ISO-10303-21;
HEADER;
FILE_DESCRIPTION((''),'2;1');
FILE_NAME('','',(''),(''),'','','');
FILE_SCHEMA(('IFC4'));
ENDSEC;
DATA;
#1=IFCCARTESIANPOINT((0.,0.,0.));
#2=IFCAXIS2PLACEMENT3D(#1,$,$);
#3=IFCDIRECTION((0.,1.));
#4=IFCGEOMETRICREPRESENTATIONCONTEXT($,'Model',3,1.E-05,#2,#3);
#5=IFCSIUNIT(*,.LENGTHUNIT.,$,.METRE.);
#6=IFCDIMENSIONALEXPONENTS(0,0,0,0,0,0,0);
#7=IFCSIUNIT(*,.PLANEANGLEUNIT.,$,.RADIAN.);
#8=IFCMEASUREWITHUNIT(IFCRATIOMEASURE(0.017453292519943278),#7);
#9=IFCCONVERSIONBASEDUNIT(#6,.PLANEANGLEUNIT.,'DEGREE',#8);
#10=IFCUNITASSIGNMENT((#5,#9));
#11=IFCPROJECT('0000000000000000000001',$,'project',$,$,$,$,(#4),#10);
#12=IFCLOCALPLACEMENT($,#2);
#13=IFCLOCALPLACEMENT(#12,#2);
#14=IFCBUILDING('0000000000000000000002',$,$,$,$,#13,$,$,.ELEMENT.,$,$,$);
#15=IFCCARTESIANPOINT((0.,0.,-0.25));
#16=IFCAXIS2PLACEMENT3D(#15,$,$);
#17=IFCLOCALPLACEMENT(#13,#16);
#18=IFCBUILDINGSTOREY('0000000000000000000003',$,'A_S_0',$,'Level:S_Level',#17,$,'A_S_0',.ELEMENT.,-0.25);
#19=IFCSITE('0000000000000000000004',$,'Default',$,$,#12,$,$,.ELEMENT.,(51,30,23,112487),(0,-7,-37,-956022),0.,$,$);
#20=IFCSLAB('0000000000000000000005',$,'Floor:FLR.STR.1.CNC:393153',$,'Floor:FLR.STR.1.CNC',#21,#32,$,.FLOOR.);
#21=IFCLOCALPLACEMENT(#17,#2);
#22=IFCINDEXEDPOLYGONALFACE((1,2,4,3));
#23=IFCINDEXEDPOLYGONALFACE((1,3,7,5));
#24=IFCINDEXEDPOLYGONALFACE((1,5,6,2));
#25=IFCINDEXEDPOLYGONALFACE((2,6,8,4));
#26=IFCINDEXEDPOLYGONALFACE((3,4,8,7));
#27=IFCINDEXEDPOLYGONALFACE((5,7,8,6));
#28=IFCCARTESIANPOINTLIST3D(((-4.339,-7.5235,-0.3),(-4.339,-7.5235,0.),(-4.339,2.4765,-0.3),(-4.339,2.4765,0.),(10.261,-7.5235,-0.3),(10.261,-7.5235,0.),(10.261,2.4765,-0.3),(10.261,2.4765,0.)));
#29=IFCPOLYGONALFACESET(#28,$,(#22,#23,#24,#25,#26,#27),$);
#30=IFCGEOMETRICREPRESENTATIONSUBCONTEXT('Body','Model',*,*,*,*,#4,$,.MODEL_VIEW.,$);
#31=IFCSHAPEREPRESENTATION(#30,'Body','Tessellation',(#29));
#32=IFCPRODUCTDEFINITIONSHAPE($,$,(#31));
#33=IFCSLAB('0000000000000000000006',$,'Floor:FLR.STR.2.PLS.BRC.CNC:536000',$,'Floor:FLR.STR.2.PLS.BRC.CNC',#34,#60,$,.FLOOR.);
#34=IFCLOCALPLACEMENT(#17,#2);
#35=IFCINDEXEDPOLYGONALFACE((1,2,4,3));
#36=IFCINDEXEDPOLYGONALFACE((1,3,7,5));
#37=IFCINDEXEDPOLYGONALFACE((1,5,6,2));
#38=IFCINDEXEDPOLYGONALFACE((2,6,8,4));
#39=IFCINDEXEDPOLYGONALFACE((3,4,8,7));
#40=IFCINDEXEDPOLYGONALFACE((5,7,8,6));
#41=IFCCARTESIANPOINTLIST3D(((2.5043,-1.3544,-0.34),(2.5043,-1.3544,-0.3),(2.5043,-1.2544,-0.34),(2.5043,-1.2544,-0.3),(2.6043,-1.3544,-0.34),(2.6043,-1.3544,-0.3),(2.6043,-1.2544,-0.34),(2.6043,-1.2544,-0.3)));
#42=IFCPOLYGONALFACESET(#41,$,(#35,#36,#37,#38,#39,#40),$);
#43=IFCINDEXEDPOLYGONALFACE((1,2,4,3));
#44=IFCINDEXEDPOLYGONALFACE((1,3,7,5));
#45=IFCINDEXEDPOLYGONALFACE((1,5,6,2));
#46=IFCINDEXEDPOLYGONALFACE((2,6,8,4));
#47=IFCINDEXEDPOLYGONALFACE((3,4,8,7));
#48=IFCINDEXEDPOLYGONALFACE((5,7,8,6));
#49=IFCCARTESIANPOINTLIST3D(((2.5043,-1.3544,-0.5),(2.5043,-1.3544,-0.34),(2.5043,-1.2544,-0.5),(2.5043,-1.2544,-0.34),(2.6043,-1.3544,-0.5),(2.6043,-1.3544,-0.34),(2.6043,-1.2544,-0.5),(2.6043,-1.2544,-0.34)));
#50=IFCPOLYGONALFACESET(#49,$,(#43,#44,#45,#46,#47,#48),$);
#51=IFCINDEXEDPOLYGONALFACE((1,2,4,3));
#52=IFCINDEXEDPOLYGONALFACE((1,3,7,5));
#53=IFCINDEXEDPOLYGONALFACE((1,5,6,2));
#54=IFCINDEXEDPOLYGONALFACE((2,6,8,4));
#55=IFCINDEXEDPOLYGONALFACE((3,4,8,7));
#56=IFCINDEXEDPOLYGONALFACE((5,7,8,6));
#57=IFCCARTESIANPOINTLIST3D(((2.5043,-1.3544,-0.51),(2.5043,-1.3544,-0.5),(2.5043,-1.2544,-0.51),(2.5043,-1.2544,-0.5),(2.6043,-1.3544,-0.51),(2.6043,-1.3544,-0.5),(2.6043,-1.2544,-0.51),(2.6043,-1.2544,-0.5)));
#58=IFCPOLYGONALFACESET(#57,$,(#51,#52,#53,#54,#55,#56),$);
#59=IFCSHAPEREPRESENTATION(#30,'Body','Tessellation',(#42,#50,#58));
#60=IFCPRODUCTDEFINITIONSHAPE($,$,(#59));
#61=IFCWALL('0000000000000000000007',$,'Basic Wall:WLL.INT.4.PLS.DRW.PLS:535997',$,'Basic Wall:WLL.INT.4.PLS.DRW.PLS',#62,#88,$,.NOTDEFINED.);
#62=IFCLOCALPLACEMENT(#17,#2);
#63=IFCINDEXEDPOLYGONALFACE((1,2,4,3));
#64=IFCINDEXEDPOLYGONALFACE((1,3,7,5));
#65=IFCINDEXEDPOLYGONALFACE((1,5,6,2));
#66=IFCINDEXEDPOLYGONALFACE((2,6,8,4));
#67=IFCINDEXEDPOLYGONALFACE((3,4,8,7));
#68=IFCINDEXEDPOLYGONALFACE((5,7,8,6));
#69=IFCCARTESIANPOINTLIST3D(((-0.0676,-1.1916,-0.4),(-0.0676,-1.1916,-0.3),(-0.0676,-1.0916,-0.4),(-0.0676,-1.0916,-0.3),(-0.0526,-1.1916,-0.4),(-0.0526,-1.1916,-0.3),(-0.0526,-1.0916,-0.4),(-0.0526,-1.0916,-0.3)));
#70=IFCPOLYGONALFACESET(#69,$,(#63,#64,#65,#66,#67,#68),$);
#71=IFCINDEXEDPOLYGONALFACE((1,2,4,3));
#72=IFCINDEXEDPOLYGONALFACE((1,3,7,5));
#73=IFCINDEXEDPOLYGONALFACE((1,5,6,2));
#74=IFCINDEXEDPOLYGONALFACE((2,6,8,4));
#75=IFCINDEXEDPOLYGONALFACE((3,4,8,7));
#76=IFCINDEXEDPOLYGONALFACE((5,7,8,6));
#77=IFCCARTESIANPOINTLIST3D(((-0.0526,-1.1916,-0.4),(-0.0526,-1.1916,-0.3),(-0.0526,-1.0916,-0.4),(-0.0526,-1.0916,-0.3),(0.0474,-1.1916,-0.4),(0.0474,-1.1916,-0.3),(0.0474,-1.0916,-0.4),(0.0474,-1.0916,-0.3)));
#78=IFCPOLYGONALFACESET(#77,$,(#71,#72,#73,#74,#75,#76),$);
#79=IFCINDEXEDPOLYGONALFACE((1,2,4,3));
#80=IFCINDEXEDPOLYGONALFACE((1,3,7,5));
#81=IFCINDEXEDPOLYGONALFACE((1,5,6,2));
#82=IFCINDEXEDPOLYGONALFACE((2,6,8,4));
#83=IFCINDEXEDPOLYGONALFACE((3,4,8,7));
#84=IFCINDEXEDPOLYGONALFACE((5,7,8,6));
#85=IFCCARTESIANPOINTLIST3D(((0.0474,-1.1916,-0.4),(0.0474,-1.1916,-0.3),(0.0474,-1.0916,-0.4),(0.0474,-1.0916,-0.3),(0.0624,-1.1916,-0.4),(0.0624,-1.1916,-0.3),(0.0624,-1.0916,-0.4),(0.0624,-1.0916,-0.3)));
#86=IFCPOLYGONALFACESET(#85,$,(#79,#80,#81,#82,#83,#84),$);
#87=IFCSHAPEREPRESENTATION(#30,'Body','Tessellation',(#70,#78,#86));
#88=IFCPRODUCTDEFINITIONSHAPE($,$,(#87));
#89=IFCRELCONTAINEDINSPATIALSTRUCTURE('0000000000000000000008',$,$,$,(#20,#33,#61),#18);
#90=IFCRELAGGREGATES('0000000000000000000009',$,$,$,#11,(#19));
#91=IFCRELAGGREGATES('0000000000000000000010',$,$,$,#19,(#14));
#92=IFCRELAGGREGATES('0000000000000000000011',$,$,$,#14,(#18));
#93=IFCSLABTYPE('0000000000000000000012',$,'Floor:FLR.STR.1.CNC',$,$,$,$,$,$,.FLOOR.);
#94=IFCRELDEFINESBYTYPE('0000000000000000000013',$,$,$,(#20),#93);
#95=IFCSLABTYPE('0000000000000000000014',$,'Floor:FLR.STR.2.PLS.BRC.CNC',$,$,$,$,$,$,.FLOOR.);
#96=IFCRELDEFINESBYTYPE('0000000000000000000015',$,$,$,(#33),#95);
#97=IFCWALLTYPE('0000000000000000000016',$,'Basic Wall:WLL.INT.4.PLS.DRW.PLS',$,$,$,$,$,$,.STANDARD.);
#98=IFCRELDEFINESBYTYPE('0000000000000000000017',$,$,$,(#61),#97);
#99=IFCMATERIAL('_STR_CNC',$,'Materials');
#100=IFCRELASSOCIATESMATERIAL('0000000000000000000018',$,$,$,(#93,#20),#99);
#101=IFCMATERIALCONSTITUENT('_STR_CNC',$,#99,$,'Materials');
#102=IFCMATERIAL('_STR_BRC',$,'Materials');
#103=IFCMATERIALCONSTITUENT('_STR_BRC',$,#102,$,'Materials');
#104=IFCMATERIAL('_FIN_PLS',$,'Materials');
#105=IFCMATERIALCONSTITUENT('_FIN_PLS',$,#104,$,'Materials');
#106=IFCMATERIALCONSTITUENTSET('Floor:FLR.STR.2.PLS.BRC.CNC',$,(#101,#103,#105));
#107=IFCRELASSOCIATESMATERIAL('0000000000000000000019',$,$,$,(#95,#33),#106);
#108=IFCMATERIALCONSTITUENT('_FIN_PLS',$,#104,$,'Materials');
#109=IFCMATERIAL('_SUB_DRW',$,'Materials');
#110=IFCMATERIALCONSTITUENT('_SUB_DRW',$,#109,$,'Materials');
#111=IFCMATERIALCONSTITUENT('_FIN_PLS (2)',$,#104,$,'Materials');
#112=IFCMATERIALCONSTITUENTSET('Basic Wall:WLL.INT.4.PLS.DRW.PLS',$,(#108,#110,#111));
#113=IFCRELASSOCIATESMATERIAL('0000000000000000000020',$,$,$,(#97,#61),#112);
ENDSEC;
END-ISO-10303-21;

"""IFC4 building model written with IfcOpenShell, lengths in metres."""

from ifc_helpers import new_model, entity, si_unit, converted_unit, direction, frame, origin, place, context, subcontext, project, spatial, indexed_curve, outline, extrude, material, constituent, constituent_set, type_object, element, save


model = new_model("IFC4")

# Units and contexts
model_context = context("Model", 3, precision=1e-05, world=origin(), true_north=direction((0.0, 1.0)))
body_context = subcontext(model_context, "Body", "Model", "MODEL_VIEW")
ifc_project = project(units=[si_unit("LENGTHUNIT", "METRE"), converted_unit("PLANEANGLEUNIT", "DEGREE", entity("IfcRatioMeasure", 0.017453292519943278), si_unit("PLANEANGLEUNIT", "RADIAN"), dimensions=[0, 0, 0, 0, 0, 0, 0])], contexts=[model_context])

# Site, building, storey
site_placement = place(None, origin())
site = spatial("IfcSite", under=ifc_project, at=site_placement, Name="Default", CompositionType="ELEMENT", RefLatitude=(51, 30, 23, 112487), RefLongitude=(0, -7, -37, -956022), RefElevation=0.0)
building_placement = place(site_placement, origin())
building = spatial("IfcBuilding", under=site, at=building_placement, CompositionType="ELEMENT")
storey_placement = place(building_placement, frame((0.0, 0.0, -0.25)))
storey = spatial("IfcBuildingStorey", under=building, at=storey_placement, Name="A_S_0", ObjectType="Level:S_Level", LongName="A_S_0", CompositionType="ELEMENT", Elevation=-0.25)

# Slabs
ifc_material_1 = material(Name="_STR_CNC", Category="Materials")
slab_type_1 = type_object("IfcSlabType", Name="Floor:FLR.STR.1.CNC", PredefinedType="FLOOR", material=ifc_material_1)
slab_1_placement = place(storey_placement, origin())
element("IfcSlab", 1, at=slab_1_placement, inside=storey, type_object=slab_type_1, material=ifc_material_1, Name="Floor:FLR.STR.1.CNC:393153", ObjectType="Floor:FLR.STR.1.CNC", PredefinedType="FLOOR", context=body_context, shape_type="SweptSolid", body=[
    extrude(outline(indexed_curve([(-5.0, -7.3), (5.0, -7.3), (5.0, 7.3), (-5.0, 7.3), (-5.0, -7.3)], self_intersect=False)), frame((2.961, -2.5235, 0.0), z_axis=(0.0, 0.0, -1.0), x_axis=(0.0, 1.0, 0.0)), (0.0, 0.0, 1.0), 0.3),
])
ifc_constituent_1 = constituent(ifc_material_1, Name="_STR_CNC", Category="Materials")
ifc_material_2 = material(Name="_STR_BRC", Category="Materials")
ifc_constituent_2 = constituent(ifc_material_2, Name="_STR_BRC", Category="Materials")
ifc_material_3 = material(Name="_FIN_PLS", Category="Materials")
ifc_constituent_3 = constituent(ifc_material_3, Name="_FIN_PLS", Category="Materials")
ifc_constituent_set_1 = constituent_set(constituents=[ifc_constituent_1, ifc_constituent_2, ifc_constituent_3], Name="Floor:FLR.STR.2.PLS.BRC.CNC")
slab_type_2 = type_object("IfcSlabType", Name="Floor:FLR.STR.2.PLS.BRC.CNC", PredefinedType="FLOOR", material=ifc_constituent_set_1)
slab_2_placement = place(storey_placement, origin())
element("IfcSlab", 2, at=slab_2_placement, inside=storey, type_object=slab_type_2, material=ifc_constituent_set_1, Name="Floor:FLR.STR.2.PLS.BRC.CNC:536000", ObjectType="Floor:FLR.STR.2.PLS.BRC.CNC", PredefinedType="FLOOR", context=body_context, shape_type="SweptSolid", body=[
    extrude(outline(indexed_curve([(-0.05, -0.05), (0.05, -0.05), (0.05, 0.05), (-0.05, 0.05), (-0.05, -0.05)], self_intersect=False)), frame((2.5543, -1.3044, -0.34), z_axis=(0.0, 0.0, 1.0), x_axis=(-1.0, 0.0, 0.0)), (0.0, 0.0, 1.0), 0.04),
    extrude(outline(indexed_curve([(-0.05, -0.05), (0.05, -0.05), (0.05, 0.05), (-0.05, 0.05), (-0.05, -0.05)], self_intersect=False)), frame((2.5543, -1.3044, -0.5), z_axis=(0.0, 0.0, 1.0), x_axis=(-1.0, 0.0, 0.0)), (0.0, 0.0, 1.0), 0.16),
    extrude(outline(indexed_curve([(-0.05, -0.05), (0.05, -0.05), (0.05, 0.05), (-0.05, 0.05), (-0.05, -0.05)], self_intersect=False)), frame((2.5543, -1.3044, -0.51), z_axis=(0.0, 0.0, 1.0), x_axis=(-1.0, 0.0, 0.0)), (0.0, 0.0, 1.0), 0.01),
])

# Wall
ifc_constituent_4 = constituent(ifc_material_3, Name="_FIN_PLS", Category="Materials")
ifc_material_4 = material(Name="_SUB_DRW", Category="Materials")
ifc_constituent_5 = constituent(ifc_material_4, Name="_SUB_DRW", Category="Materials")
ifc_constituent_6 = constituent(ifc_material_3, Name="_FIN_PLS (2)", Category="Materials")
ifc_constituent_set_2 = constituent_set(constituents=[ifc_constituent_4, ifc_constituent_5, ifc_constituent_6], Name="Basic Wall:WLL.INT.4.PLS.DRW.PLS")
wall_type = type_object("IfcWallType", Name="Basic Wall:WLL.INT.4.PLS.DRW.PLS", PredefinedType="STANDARD", material=ifc_constituent_set_2)
wall_placement = place(storey_placement, frame((-0.0026, -1.0916, -0.4), z_axis=(0.0, 0.0, 1.0), x_axis=(0.0, -1.0, 0.0)))
element("IfcWall", 3, at=wall_placement, inside=storey, type_object=wall_type, material=ifc_constituent_set_2, Name="Basic Wall:WLL.INT.4.PLS.DRW.PLS:535997", ObjectType="Basic Wall:WLL.INT.4.PLS.DRW.PLS", PredefinedType="NOTDEFINED", context=body_context, shape_type="SweptSolid", body=[
    extrude(outline(indexed_curve([(-0.0075, -0.05), (0.0075, -0.05), (0.0075, 0.05), (-0.0075, 0.05), (-0.0075, -0.05)], self_intersect=False)), frame((0.05, -0.0575, 0.0), z_axis=(0.0, 0.0, 1.0), x_axis=(0.0, 1.0, 0.0)), (0.0, 0.0, 1.0), 0.1),
    extrude(outline(indexed_curve([(-0.05, -0.05), (0.05, -0.05), (0.05, 0.05), (-0.05, 0.05), (-0.05, -0.05)], self_intersect=False)), frame((0.05, 0.0, 0.0)), (0.0, 0.0, 1.0), 0.1),
    extrude(outline(indexed_curve([(-0.0075, -0.05), (0.0075, -0.05), (0.0075, 0.05), (-0.0075, 0.05), (-0.0075, -0.05)], self_intersect=False)), frame((0.05, 0.0575, 0.0), z_axis=(0.0, 0.0, 1.0), x_axis=(0.0, -1.0, 0.0)), (0.0, 0.0, 1.0), 0.1),
])

save(model, "model.ifc")
